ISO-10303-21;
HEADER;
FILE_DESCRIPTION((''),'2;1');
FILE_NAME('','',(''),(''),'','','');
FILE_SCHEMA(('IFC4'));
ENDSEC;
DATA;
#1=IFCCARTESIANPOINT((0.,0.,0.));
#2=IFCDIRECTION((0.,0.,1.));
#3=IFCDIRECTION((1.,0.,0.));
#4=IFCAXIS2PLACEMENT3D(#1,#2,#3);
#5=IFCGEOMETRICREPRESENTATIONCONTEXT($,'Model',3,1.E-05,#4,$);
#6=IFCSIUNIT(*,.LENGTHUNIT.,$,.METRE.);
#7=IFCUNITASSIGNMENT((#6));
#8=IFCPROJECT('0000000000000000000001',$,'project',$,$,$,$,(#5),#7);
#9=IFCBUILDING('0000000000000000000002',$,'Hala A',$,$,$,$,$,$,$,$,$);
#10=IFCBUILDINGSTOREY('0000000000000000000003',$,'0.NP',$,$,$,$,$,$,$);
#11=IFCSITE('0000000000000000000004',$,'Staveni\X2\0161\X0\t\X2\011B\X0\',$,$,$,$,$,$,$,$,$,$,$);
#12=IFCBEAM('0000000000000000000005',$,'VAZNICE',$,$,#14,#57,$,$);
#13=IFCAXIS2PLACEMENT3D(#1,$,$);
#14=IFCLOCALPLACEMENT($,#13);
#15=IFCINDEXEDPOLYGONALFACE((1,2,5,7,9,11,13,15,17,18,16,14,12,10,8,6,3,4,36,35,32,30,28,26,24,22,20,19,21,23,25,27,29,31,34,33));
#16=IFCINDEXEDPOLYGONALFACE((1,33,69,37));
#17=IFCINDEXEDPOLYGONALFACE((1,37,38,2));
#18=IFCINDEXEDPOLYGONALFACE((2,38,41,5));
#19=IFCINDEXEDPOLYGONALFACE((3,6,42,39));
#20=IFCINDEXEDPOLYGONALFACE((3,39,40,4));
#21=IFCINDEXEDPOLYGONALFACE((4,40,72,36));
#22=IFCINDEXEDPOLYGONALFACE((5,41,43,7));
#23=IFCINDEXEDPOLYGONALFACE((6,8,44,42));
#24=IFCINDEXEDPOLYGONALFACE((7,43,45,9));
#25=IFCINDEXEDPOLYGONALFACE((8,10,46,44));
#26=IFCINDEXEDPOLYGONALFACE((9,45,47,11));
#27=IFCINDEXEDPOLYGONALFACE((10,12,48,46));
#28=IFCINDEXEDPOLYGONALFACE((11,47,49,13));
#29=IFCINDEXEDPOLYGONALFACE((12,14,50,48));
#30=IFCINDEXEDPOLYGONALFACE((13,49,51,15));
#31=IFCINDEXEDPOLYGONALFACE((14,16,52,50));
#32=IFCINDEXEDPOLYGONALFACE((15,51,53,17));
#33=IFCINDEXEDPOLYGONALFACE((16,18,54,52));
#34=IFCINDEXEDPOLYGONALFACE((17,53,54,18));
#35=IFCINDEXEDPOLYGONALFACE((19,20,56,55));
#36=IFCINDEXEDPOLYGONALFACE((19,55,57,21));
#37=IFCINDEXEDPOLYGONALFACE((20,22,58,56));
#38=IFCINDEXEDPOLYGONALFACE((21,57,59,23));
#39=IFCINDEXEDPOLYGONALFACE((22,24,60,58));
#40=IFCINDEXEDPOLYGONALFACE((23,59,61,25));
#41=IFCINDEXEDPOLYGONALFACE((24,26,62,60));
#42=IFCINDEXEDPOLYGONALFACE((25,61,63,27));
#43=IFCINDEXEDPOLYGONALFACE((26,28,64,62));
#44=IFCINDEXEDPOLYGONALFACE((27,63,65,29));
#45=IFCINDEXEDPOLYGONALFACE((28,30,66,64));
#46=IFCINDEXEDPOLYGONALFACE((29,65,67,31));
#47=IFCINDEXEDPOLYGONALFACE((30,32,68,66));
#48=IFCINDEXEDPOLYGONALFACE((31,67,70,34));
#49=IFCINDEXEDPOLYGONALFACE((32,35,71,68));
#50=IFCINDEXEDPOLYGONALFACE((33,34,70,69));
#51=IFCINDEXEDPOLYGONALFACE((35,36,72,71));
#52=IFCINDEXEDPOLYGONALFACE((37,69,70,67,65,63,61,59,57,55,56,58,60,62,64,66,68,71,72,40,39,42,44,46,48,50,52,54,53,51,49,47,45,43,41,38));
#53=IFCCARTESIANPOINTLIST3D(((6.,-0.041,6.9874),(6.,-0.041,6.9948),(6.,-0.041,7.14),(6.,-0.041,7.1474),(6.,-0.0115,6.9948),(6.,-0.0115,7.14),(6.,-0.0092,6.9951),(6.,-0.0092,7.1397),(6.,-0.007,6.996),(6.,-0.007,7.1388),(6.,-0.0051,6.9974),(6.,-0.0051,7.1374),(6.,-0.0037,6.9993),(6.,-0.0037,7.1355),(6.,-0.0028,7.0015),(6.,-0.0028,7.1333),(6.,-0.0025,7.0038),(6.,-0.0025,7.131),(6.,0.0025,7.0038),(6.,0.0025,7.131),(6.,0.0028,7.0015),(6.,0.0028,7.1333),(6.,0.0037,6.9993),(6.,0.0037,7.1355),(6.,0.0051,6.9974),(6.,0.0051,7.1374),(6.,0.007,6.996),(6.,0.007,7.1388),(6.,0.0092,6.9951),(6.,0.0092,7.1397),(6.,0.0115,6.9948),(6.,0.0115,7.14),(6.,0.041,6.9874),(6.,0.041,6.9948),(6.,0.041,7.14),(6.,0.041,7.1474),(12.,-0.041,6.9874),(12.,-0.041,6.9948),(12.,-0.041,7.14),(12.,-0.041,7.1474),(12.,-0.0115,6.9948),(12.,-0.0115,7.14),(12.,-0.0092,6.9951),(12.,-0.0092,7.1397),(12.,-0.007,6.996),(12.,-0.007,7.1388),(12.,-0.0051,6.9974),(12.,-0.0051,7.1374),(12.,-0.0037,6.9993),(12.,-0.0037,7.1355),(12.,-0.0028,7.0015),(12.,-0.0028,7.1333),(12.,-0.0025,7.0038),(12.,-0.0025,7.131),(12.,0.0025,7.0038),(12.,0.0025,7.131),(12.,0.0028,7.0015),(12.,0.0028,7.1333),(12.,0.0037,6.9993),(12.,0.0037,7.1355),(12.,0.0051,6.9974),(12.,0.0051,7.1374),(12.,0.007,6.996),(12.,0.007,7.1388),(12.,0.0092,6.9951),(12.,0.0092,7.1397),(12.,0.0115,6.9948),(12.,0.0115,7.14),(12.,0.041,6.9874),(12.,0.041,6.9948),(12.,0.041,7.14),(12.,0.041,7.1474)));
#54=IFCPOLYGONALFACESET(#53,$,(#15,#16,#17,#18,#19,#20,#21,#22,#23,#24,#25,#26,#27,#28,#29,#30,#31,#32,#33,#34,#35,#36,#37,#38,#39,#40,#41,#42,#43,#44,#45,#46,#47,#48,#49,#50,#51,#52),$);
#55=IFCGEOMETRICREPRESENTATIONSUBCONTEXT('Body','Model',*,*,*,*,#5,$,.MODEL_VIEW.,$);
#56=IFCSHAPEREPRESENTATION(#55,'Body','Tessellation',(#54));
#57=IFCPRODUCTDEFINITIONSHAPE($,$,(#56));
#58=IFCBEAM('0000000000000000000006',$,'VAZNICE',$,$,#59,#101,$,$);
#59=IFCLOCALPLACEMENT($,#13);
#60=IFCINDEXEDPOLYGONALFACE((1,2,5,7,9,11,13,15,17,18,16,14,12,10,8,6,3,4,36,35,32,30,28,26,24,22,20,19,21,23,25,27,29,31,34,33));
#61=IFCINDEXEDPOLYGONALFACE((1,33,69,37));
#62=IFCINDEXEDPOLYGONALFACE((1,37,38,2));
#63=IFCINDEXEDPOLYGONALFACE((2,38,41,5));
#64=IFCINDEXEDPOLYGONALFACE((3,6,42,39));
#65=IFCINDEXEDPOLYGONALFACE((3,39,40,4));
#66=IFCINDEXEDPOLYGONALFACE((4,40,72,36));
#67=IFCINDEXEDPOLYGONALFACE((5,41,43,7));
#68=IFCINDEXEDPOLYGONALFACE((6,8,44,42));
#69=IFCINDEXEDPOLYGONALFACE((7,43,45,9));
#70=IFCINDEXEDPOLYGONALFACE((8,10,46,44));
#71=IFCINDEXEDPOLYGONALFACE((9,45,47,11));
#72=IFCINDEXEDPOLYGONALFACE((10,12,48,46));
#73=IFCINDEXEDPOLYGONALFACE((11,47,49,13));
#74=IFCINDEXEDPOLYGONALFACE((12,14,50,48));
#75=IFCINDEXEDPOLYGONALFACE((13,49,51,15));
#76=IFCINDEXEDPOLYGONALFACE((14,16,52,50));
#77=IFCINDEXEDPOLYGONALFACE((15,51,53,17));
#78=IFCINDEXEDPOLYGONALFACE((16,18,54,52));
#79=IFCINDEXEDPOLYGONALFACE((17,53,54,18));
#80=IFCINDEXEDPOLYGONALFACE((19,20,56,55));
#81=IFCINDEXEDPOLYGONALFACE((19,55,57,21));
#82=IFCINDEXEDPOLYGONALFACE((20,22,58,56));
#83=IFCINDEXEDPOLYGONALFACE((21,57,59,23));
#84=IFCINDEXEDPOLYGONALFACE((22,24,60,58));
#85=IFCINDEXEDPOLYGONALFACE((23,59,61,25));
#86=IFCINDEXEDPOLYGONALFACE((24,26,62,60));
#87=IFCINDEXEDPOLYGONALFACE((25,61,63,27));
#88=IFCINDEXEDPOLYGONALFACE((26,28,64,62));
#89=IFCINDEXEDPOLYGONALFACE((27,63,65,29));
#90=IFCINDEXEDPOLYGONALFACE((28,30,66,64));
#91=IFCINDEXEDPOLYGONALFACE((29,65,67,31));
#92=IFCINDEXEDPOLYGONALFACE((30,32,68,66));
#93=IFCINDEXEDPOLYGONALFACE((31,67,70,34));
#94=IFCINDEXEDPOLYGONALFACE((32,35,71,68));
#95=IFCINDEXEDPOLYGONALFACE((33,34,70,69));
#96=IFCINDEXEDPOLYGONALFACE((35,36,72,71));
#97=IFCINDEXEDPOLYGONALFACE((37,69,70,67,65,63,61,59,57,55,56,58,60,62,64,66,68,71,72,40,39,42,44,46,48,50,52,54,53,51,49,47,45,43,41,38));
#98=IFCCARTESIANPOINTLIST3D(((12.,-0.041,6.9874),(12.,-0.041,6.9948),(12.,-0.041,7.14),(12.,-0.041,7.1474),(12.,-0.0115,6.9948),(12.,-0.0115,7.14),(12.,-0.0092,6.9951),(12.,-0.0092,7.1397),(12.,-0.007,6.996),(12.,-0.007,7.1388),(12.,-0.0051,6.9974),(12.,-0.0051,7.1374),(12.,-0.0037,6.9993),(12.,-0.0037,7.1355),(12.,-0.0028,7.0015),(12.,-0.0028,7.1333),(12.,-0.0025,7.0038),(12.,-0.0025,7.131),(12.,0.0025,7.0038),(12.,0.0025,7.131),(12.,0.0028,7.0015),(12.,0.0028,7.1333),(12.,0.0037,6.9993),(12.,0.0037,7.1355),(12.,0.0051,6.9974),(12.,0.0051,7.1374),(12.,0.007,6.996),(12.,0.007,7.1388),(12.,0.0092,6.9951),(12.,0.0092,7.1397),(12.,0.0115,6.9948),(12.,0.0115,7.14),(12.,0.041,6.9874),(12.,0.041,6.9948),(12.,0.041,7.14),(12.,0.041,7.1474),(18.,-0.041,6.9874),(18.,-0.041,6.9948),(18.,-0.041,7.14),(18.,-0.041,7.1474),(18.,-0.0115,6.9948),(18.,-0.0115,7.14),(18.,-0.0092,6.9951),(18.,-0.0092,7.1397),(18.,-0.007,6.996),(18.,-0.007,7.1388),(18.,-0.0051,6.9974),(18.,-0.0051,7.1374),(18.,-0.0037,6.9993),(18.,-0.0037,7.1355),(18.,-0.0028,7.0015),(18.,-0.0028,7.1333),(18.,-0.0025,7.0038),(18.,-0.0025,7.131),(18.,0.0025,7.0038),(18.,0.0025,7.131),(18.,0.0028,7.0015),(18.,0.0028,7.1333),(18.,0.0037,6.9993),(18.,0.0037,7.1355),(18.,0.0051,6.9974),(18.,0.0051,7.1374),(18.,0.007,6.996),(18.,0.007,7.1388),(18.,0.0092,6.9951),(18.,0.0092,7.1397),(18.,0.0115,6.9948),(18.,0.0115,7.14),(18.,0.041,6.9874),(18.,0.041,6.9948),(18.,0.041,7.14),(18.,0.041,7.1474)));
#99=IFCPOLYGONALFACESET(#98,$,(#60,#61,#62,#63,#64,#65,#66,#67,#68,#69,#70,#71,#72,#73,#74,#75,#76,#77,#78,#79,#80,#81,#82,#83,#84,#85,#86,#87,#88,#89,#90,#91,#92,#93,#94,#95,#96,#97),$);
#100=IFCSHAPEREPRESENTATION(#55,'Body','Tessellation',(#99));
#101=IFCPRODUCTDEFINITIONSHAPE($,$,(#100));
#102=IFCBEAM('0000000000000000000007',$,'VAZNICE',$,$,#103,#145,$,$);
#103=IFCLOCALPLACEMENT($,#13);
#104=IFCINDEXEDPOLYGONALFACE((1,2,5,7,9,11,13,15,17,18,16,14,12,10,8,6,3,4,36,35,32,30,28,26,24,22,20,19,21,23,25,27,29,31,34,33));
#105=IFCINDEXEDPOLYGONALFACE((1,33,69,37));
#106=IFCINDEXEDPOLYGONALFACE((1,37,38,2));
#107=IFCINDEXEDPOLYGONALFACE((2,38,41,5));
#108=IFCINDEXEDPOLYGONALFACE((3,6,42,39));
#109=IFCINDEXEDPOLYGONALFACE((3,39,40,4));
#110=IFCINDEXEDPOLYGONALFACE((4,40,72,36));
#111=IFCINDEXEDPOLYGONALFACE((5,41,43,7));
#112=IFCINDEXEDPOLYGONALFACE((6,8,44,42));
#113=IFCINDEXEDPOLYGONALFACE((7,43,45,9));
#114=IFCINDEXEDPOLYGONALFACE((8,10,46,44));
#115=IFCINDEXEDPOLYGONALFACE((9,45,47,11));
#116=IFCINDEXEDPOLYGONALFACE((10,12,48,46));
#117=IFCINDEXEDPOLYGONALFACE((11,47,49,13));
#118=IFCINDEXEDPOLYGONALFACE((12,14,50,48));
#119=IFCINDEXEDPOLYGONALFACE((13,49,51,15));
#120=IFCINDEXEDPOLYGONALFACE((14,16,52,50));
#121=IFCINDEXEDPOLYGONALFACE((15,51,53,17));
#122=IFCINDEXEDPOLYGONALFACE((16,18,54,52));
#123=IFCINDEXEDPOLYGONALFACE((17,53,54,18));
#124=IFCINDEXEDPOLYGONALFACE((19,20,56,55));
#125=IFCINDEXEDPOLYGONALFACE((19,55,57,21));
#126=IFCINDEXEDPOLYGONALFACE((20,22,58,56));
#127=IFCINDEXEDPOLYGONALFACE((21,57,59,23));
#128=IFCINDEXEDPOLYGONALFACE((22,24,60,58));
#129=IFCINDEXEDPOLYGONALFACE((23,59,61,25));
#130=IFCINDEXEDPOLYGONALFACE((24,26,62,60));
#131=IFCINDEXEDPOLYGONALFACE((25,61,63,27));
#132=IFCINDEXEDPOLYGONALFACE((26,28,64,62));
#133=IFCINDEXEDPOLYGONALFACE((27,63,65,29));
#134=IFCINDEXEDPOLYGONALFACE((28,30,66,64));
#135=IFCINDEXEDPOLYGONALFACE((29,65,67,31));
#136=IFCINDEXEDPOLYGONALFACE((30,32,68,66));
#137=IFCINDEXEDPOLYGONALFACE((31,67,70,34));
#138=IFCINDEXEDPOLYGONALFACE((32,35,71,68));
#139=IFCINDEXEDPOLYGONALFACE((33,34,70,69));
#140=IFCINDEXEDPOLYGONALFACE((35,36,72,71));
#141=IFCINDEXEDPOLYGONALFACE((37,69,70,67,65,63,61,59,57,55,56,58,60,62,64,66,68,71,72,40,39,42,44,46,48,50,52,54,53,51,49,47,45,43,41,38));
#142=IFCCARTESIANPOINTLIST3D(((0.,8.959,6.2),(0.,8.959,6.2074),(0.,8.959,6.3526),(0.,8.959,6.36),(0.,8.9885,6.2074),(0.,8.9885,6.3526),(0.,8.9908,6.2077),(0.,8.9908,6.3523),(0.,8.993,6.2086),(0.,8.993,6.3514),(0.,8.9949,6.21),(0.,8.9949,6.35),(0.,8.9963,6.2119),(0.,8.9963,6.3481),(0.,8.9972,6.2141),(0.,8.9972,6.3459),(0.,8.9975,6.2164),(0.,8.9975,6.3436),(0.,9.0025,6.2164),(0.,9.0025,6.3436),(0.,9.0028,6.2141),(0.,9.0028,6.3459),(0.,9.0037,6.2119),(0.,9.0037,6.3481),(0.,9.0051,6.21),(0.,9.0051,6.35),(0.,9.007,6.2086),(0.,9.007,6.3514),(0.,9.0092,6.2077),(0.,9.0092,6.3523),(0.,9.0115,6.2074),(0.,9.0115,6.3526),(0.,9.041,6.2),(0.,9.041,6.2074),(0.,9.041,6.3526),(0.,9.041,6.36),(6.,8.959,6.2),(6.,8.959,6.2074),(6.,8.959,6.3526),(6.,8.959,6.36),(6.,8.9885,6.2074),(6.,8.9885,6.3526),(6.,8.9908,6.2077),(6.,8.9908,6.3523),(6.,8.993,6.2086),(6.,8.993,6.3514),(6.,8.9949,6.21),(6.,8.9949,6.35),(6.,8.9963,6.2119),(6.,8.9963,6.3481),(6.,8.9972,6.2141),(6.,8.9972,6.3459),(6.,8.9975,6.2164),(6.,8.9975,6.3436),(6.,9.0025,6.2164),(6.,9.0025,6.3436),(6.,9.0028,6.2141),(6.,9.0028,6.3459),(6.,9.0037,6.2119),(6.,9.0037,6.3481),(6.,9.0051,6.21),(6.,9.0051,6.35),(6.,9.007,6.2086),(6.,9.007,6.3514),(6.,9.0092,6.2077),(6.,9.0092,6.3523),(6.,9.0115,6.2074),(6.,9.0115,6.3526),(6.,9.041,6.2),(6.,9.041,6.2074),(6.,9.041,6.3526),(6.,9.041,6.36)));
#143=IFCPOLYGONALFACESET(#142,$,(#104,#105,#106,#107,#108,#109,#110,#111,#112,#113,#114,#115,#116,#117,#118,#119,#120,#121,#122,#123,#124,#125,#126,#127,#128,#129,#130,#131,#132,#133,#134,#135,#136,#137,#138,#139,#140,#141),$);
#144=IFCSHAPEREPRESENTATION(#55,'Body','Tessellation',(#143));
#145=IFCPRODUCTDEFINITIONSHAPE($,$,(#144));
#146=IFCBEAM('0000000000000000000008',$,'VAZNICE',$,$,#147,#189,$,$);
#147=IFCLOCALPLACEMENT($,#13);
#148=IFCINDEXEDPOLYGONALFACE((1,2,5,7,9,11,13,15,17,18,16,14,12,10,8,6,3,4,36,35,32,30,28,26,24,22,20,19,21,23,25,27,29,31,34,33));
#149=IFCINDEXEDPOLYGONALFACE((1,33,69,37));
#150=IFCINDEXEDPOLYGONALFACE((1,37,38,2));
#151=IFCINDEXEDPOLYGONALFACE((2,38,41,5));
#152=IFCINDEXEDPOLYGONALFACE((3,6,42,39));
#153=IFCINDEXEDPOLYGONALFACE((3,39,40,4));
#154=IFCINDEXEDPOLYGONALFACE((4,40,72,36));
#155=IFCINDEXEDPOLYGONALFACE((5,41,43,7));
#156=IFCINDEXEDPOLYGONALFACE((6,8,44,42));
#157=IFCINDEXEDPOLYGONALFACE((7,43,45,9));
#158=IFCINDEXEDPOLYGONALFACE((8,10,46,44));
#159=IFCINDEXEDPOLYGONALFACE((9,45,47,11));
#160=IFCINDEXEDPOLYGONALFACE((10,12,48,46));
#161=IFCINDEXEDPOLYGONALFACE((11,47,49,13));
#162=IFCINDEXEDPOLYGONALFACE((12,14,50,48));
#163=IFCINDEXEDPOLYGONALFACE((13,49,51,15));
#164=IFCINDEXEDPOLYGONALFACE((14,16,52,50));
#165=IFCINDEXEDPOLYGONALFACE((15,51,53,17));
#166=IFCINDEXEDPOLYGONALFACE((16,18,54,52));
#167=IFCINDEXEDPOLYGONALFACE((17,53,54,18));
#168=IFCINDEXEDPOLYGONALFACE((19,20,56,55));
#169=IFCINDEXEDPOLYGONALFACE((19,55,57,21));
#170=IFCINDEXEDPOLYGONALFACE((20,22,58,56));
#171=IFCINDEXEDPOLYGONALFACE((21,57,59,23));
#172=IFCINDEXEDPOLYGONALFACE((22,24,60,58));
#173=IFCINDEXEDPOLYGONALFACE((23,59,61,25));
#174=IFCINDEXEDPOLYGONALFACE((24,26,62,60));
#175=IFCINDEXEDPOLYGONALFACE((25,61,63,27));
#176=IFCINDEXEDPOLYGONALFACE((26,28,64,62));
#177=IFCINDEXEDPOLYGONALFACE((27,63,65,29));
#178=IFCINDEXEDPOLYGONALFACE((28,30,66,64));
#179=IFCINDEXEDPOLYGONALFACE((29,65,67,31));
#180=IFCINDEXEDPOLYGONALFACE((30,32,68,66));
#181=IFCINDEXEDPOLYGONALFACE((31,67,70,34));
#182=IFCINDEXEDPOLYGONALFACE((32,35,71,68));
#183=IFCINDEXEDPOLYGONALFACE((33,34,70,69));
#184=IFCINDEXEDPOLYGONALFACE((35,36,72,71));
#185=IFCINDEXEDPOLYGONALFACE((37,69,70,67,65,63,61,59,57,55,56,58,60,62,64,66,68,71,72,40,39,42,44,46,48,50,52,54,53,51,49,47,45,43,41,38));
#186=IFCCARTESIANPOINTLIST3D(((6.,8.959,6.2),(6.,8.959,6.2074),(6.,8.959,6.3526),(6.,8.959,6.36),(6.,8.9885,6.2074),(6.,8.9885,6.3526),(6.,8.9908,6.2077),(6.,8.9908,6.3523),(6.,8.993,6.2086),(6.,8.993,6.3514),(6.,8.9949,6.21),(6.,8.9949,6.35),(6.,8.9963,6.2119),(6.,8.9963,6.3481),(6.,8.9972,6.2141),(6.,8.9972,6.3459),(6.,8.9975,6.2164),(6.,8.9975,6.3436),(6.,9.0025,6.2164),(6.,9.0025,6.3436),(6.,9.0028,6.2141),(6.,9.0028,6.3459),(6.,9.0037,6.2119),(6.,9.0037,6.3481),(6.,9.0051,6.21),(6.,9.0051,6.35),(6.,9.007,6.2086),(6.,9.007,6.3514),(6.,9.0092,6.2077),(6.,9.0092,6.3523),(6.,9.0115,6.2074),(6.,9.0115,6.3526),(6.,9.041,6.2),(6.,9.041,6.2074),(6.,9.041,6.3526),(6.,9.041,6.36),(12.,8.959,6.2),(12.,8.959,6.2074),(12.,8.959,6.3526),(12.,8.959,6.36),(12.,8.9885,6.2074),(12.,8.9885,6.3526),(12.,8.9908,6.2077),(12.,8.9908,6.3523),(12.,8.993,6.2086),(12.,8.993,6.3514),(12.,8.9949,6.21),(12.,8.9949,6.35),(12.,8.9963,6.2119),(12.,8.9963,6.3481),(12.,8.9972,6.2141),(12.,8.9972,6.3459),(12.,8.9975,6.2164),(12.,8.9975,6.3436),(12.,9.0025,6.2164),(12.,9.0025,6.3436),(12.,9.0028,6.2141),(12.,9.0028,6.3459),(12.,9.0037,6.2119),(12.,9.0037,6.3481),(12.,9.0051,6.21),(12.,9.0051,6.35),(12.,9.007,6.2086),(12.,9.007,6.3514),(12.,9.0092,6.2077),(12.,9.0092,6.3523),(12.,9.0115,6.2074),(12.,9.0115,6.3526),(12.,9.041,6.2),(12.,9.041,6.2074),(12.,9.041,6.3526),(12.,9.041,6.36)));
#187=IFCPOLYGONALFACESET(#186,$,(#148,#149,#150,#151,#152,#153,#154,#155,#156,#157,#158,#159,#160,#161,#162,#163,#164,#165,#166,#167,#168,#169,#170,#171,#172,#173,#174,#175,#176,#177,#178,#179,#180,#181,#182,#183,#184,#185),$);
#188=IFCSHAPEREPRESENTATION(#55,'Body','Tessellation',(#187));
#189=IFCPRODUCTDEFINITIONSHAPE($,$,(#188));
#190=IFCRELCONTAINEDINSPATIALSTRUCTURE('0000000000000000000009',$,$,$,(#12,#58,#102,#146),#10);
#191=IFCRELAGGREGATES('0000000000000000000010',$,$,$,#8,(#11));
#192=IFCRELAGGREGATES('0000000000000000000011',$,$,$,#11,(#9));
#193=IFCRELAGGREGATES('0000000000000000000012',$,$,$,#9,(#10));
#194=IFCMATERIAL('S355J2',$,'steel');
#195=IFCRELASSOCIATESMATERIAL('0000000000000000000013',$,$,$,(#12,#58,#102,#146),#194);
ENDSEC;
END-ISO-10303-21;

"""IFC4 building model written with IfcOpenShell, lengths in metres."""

from ifc_helpers import new_model, si_unit, frame, origin_with_axes, place, context, subcontext, project, spatial, i_section, extrude, material, element, save


model = new_model("IFC4")

# Units and contexts
model_context = context("Model", 3, precision=1e-05, world=origin_with_axes())
body_context = subcontext(model_context, "Body", "Model", "MODEL_VIEW")
ifc_project = project(units=[si_unit("LENGTHUNIT", "METRE")], contexts=[model_context])

# Site, building, storey
site = spatial("IfcSite", under=ifc_project, Name="Staveniště")
building = spatial("IfcBuilding", under=site, Name="Hala A")
storey = spatial("IfcBuildingStorey", under=building, Name="0.NP")

# Shared definitions
ifc_material = material(Name="S355J2", Category="steel")

# Beams
for number, where, z_axis, x_axis, name in (
    (1, (6.0, 0.0, 7.0674), (1.0, 0.0, 0.0), (0.0, 1.0, 0.0), "VAZNICE"),
    (2, (12.0, 0.0, 7.0674), (1.0, 0.0, 0.0), (0.0, 1.0, 0.0), "VAZNICE"),
    (3, (0.0, 9.0, 6.28), (1.0, 0.0, 0.0), (0.0, 1.0, 0.0), "VAZNICE"),
    (4, (6.0, 9.0, 6.28), (1.0, 0.0, 0.0), (0.0, 1.0, 0.0), "VAZNICE"),
):
    element("IfcBeam", number, at=place(None, frame(where, z_axis=z_axis, x_axis=x_axis)), inside=storey, material=ifc_material, Name=name, context=body_context, shape_type="SweptSolid", body=[
        extrude(i_section(OverallWidth=0.082, OverallDepth=0.16, WebThickness=0.005, FlangeThickness=0.0074, FilletRadius=0.009), origin_with_axes(), (0.0, 0.0, 1.0), 6.0),
    ])

save(model, "model.ifc")
